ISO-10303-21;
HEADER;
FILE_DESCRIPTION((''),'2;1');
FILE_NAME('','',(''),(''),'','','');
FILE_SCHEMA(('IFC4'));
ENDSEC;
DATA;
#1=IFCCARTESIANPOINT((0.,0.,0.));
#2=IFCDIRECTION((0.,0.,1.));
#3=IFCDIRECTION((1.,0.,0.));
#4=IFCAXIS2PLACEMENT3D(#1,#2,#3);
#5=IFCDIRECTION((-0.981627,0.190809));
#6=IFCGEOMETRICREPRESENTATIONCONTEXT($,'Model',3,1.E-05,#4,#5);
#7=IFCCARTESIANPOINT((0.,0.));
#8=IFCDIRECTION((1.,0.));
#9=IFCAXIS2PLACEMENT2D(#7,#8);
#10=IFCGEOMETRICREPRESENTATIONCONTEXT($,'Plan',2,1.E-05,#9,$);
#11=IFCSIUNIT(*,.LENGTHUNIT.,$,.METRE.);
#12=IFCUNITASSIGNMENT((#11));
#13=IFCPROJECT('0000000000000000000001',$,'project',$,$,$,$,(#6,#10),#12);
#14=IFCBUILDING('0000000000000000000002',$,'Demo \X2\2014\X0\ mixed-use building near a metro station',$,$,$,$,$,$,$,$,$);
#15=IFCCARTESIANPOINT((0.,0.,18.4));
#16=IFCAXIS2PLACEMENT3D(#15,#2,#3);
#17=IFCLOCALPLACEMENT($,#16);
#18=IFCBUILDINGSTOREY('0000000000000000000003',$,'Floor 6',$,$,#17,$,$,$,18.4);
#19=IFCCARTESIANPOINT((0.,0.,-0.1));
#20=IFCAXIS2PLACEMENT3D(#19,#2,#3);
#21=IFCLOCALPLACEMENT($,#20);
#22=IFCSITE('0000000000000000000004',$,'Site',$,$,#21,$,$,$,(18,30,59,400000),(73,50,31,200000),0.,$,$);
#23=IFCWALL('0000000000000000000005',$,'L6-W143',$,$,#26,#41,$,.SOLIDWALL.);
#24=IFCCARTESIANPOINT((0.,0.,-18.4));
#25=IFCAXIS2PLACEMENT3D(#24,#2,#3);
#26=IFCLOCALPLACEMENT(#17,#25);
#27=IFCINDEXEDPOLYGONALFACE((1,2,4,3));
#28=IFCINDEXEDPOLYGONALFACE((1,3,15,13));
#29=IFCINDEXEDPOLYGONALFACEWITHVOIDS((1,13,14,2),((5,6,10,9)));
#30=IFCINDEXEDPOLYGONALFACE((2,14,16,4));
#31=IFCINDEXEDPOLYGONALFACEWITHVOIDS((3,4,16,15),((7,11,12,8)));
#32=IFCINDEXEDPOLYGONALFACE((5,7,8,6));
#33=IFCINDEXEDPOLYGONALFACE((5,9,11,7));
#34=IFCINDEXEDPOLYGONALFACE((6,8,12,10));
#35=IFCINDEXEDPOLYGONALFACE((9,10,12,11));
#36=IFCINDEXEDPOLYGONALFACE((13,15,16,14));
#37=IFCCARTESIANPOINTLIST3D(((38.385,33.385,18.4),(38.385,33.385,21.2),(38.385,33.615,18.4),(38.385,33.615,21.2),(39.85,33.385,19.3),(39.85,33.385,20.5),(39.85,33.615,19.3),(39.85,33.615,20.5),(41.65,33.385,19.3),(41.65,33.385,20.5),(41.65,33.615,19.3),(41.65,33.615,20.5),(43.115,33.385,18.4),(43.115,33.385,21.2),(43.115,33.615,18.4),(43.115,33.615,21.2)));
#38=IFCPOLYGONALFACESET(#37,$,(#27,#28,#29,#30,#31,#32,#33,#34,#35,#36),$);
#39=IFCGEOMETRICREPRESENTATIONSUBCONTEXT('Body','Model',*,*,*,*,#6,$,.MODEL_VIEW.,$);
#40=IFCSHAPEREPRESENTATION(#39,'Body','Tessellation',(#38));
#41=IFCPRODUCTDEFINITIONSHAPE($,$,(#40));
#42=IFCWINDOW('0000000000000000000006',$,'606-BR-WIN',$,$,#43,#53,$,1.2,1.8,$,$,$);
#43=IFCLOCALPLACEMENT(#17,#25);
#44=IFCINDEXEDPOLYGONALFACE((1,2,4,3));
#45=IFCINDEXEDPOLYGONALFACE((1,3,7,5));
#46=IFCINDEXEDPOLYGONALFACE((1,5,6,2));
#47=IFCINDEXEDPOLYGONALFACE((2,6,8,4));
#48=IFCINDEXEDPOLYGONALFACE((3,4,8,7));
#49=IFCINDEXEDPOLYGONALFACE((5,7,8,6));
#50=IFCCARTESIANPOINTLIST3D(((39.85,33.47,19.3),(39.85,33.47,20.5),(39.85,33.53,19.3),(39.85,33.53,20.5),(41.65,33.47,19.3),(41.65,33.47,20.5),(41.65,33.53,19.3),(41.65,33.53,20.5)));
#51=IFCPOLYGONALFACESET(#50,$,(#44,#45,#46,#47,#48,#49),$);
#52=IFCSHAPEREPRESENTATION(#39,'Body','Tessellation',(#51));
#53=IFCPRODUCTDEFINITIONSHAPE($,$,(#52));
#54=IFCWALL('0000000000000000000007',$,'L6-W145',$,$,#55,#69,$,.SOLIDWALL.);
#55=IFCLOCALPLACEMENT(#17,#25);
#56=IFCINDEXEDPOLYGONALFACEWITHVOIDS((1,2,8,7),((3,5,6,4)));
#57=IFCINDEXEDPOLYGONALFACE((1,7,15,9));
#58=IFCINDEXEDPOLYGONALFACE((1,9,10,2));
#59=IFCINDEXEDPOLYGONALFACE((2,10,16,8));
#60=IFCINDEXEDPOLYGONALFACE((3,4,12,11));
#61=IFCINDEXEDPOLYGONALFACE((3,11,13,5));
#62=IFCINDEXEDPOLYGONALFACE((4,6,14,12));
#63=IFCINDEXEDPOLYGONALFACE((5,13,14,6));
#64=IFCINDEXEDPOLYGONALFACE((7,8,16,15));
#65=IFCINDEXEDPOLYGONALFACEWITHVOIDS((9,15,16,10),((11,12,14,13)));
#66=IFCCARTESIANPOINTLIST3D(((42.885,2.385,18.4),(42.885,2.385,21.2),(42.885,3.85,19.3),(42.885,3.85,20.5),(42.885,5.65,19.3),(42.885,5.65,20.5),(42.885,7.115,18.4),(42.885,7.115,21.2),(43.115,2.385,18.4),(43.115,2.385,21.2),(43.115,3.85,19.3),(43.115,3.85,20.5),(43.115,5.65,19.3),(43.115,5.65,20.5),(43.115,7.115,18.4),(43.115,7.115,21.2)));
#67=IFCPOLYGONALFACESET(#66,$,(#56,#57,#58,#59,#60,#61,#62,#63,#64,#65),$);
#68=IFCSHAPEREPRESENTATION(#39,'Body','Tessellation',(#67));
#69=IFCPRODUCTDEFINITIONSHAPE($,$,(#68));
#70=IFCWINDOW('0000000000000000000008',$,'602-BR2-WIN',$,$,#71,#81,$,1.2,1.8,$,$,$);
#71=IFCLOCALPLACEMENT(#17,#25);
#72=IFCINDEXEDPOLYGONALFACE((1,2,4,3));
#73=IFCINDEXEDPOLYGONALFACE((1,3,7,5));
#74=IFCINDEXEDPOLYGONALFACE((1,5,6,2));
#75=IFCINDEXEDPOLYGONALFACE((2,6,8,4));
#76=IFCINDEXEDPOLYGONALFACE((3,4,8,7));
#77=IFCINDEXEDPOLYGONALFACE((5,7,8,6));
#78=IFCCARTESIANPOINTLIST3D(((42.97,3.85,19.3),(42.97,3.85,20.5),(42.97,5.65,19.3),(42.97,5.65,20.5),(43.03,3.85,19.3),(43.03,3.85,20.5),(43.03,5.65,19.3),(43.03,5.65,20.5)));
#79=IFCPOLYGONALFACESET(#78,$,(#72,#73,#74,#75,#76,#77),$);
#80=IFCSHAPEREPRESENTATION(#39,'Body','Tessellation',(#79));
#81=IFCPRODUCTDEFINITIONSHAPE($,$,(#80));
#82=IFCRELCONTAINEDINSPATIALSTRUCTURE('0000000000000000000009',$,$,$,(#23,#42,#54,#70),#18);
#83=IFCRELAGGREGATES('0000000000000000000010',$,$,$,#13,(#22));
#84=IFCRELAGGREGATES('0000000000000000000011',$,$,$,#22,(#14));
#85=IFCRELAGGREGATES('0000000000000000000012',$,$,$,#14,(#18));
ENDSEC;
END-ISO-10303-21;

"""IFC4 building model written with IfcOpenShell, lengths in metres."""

from ifc_helpers import new_model, si_unit, direction, frame, origin_with_axes, origin_2d_with_axis, place, context, subcontext, project, spatial, line, indexed_curve, outline, extrude, element, fill, save


model = new_model("IFC4")

# Units and contexts
model_context = context("Model", 3, precision=1e-05, world=origin_with_axes(), true_north=direction((-0.981627, 0.190809)))
plan_context = context("Plan", 2, precision=1e-05, world=origin_2d_with_axis())
body_context = subcontext(model_context, "Body", "Model", "MODEL_VIEW")
ifc_project = project(units=[si_unit("LENGTHUNIT", "METRE")], contexts=[model_context, plan_context])

# Site, building, storey
site_placement = place(None, frame((0.0, 0.0, -0.1), z_axis=(0.0, 0.0, 1.0), x_axis=(1.0, 0.0, 0.0)))
site = spatial("IfcSite", under=ifc_project, at=site_placement, Name="Site", RefLatitude=(18, 30, 59, 400000), RefLongitude=(73, 50, 31, 200000), RefElevation=0.0)
building = spatial("IfcBuilding", under=site, Name="Demo — mixed-use building near a metro station")
storey_placement = place(None, frame((0.0, 0.0, 18.4), z_axis=(0.0, 0.0, 1.0), x_axis=(1.0, 0.0, 0.0)))
storey = spatial("IfcBuildingStorey", under=building, at=storey_placement, Name="Floor 6", Elevation=18.4)

# Wall, opening, window
wall_1_placement = place(storey_placement, frame((0.0, 0.0, -18.4), z_axis=(0.0, 0.0, 1.0), x_axis=(1.0, 0.0, 0.0)))
wall_1 = element("IfcWall", 1, at=wall_1_placement, inside=storey, Name="L6-W143", PredefinedType="SOLIDWALL", context=body_context, shape_type="SweptSolid", body=[
    extrude(outline(indexed_curve([(43.115, 33.385), (38.385, 33.385), (38.385, 33.615), (43.115, 33.615)], segments=[line(1, 2, 3, 4, 1)])), frame((0.0, 0.0, 18.4), z_axis=(0.0, 0.0, 1.0), x_axis=(1.0, 0.0, 0.0)), (0.0, 0.0, 1.0), 2.8),
])
opening_1_placement = place(wall_1_placement, origin_with_axes())
opening_1 = element("IfcOpeningElement", 2, at=opening_1_placement, cuts=wall_1, context=body_context, shape_type="SweptSolid", body=[
    extrude(outline(indexed_curve([(41.65, 33.335), (39.85, 33.335), (39.85, 33.665), (41.65, 33.665)], segments=[line(1, 2, 3, 4, 1)])), frame((0.0, 0.0, 19.3), z_axis=(0.0, 0.0, 1.0), x_axis=(1.0, 0.0, 0.0)), (0.0, 0.0, 1.0), 1.2),
])
window_1_placement = place(storey_placement, frame((0.0, 0.0, -18.4), z_axis=(0.0, 0.0, 1.0), x_axis=(1.0, 0.0, 0.0)))
window_1 = element("IfcWindow", 3, at=window_1_placement, inside=storey, Name="606-BR-WIN", OverallHeight=1.2, OverallWidth=1.8, context=body_context, shape_type="SweptSolid", body=[
    extrude(outline(indexed_curve([(41.65, 33.47), (39.85, 33.47), (39.85, 33.53), (41.65, 33.53)], segments=[line(1, 2, 3, 4, 1)])), frame((0.0, 0.0, 19.3), z_axis=(0.0, 0.0, 1.0), x_axis=(1.0, 0.0, 0.0)), (0.0, 0.0, 1.0), 1.2),
])
fill(opening_1, window_1)

# Wall, opening, window
wall_2_placement = place(storey_placement, frame((0.0, 0.0, -18.4), z_axis=(0.0, 0.0, 1.0), x_axis=(1.0, 0.0, 0.0)))
wall_2 = element("IfcWall", 4, at=wall_2_placement, inside=storey, Name="L6-W145", PredefinedType="SOLIDWALL", context=body_context, shape_type="SweptSolid", body=[
    extrude(outline(indexed_curve([(42.885, 2.385), (42.885, 7.115), (43.115, 7.115), (43.115, 2.385)], segments=[line(1, 2, 3, 4, 1)])), frame((0.0, 0.0, 18.4), z_axis=(0.0, 0.0, 1.0), x_axis=(1.0, 0.0, 0.0)), (0.0, 0.0, 1.0), 2.8),
])
opening_2_placement = place(wall_2_placement, origin_with_axes())
opening_2 = element("IfcOpeningElement", 5, at=opening_2_placement, cuts=wall_2, context=body_context, shape_type="SweptSolid", body=[
    extrude(outline(indexed_curve([(42.835, 3.85), (42.835, 5.65), (43.165, 5.65), (43.165, 3.85)], segments=[line(1, 2, 3, 4, 1)])), frame((0.0, 0.0, 19.3), z_axis=(0.0, 0.0, 1.0), x_axis=(1.0, 0.0, 0.0)), (0.0, 0.0, 1.0), 1.2),
])
window_2_placement = place(storey_placement, frame((0.0, 0.0, -18.4), z_axis=(0.0, 0.0, 1.0), x_axis=(1.0, 0.0, 0.0)))
window_2 = element("IfcWindow", 6, at=window_2_placement, inside=storey, Name="602-BR2-WIN", OverallHeight=1.2, OverallWidth=1.8, context=body_context, shape_type="SweptSolid", body=[
    extrude(outline(indexed_curve([(42.97, 3.85), (42.97, 5.65), (43.03, 5.65), (43.03, 3.85)], segments=[line(1, 2, 3, 4, 1)])), frame((0.0, 0.0, 19.3), z_axis=(0.0, 0.0, 1.0), x_axis=(1.0, 0.0, 0.0)), (0.0, 0.0, 1.0), 1.2),
])
fill(opening_2, window_2)

save(model, "model.ifc")
